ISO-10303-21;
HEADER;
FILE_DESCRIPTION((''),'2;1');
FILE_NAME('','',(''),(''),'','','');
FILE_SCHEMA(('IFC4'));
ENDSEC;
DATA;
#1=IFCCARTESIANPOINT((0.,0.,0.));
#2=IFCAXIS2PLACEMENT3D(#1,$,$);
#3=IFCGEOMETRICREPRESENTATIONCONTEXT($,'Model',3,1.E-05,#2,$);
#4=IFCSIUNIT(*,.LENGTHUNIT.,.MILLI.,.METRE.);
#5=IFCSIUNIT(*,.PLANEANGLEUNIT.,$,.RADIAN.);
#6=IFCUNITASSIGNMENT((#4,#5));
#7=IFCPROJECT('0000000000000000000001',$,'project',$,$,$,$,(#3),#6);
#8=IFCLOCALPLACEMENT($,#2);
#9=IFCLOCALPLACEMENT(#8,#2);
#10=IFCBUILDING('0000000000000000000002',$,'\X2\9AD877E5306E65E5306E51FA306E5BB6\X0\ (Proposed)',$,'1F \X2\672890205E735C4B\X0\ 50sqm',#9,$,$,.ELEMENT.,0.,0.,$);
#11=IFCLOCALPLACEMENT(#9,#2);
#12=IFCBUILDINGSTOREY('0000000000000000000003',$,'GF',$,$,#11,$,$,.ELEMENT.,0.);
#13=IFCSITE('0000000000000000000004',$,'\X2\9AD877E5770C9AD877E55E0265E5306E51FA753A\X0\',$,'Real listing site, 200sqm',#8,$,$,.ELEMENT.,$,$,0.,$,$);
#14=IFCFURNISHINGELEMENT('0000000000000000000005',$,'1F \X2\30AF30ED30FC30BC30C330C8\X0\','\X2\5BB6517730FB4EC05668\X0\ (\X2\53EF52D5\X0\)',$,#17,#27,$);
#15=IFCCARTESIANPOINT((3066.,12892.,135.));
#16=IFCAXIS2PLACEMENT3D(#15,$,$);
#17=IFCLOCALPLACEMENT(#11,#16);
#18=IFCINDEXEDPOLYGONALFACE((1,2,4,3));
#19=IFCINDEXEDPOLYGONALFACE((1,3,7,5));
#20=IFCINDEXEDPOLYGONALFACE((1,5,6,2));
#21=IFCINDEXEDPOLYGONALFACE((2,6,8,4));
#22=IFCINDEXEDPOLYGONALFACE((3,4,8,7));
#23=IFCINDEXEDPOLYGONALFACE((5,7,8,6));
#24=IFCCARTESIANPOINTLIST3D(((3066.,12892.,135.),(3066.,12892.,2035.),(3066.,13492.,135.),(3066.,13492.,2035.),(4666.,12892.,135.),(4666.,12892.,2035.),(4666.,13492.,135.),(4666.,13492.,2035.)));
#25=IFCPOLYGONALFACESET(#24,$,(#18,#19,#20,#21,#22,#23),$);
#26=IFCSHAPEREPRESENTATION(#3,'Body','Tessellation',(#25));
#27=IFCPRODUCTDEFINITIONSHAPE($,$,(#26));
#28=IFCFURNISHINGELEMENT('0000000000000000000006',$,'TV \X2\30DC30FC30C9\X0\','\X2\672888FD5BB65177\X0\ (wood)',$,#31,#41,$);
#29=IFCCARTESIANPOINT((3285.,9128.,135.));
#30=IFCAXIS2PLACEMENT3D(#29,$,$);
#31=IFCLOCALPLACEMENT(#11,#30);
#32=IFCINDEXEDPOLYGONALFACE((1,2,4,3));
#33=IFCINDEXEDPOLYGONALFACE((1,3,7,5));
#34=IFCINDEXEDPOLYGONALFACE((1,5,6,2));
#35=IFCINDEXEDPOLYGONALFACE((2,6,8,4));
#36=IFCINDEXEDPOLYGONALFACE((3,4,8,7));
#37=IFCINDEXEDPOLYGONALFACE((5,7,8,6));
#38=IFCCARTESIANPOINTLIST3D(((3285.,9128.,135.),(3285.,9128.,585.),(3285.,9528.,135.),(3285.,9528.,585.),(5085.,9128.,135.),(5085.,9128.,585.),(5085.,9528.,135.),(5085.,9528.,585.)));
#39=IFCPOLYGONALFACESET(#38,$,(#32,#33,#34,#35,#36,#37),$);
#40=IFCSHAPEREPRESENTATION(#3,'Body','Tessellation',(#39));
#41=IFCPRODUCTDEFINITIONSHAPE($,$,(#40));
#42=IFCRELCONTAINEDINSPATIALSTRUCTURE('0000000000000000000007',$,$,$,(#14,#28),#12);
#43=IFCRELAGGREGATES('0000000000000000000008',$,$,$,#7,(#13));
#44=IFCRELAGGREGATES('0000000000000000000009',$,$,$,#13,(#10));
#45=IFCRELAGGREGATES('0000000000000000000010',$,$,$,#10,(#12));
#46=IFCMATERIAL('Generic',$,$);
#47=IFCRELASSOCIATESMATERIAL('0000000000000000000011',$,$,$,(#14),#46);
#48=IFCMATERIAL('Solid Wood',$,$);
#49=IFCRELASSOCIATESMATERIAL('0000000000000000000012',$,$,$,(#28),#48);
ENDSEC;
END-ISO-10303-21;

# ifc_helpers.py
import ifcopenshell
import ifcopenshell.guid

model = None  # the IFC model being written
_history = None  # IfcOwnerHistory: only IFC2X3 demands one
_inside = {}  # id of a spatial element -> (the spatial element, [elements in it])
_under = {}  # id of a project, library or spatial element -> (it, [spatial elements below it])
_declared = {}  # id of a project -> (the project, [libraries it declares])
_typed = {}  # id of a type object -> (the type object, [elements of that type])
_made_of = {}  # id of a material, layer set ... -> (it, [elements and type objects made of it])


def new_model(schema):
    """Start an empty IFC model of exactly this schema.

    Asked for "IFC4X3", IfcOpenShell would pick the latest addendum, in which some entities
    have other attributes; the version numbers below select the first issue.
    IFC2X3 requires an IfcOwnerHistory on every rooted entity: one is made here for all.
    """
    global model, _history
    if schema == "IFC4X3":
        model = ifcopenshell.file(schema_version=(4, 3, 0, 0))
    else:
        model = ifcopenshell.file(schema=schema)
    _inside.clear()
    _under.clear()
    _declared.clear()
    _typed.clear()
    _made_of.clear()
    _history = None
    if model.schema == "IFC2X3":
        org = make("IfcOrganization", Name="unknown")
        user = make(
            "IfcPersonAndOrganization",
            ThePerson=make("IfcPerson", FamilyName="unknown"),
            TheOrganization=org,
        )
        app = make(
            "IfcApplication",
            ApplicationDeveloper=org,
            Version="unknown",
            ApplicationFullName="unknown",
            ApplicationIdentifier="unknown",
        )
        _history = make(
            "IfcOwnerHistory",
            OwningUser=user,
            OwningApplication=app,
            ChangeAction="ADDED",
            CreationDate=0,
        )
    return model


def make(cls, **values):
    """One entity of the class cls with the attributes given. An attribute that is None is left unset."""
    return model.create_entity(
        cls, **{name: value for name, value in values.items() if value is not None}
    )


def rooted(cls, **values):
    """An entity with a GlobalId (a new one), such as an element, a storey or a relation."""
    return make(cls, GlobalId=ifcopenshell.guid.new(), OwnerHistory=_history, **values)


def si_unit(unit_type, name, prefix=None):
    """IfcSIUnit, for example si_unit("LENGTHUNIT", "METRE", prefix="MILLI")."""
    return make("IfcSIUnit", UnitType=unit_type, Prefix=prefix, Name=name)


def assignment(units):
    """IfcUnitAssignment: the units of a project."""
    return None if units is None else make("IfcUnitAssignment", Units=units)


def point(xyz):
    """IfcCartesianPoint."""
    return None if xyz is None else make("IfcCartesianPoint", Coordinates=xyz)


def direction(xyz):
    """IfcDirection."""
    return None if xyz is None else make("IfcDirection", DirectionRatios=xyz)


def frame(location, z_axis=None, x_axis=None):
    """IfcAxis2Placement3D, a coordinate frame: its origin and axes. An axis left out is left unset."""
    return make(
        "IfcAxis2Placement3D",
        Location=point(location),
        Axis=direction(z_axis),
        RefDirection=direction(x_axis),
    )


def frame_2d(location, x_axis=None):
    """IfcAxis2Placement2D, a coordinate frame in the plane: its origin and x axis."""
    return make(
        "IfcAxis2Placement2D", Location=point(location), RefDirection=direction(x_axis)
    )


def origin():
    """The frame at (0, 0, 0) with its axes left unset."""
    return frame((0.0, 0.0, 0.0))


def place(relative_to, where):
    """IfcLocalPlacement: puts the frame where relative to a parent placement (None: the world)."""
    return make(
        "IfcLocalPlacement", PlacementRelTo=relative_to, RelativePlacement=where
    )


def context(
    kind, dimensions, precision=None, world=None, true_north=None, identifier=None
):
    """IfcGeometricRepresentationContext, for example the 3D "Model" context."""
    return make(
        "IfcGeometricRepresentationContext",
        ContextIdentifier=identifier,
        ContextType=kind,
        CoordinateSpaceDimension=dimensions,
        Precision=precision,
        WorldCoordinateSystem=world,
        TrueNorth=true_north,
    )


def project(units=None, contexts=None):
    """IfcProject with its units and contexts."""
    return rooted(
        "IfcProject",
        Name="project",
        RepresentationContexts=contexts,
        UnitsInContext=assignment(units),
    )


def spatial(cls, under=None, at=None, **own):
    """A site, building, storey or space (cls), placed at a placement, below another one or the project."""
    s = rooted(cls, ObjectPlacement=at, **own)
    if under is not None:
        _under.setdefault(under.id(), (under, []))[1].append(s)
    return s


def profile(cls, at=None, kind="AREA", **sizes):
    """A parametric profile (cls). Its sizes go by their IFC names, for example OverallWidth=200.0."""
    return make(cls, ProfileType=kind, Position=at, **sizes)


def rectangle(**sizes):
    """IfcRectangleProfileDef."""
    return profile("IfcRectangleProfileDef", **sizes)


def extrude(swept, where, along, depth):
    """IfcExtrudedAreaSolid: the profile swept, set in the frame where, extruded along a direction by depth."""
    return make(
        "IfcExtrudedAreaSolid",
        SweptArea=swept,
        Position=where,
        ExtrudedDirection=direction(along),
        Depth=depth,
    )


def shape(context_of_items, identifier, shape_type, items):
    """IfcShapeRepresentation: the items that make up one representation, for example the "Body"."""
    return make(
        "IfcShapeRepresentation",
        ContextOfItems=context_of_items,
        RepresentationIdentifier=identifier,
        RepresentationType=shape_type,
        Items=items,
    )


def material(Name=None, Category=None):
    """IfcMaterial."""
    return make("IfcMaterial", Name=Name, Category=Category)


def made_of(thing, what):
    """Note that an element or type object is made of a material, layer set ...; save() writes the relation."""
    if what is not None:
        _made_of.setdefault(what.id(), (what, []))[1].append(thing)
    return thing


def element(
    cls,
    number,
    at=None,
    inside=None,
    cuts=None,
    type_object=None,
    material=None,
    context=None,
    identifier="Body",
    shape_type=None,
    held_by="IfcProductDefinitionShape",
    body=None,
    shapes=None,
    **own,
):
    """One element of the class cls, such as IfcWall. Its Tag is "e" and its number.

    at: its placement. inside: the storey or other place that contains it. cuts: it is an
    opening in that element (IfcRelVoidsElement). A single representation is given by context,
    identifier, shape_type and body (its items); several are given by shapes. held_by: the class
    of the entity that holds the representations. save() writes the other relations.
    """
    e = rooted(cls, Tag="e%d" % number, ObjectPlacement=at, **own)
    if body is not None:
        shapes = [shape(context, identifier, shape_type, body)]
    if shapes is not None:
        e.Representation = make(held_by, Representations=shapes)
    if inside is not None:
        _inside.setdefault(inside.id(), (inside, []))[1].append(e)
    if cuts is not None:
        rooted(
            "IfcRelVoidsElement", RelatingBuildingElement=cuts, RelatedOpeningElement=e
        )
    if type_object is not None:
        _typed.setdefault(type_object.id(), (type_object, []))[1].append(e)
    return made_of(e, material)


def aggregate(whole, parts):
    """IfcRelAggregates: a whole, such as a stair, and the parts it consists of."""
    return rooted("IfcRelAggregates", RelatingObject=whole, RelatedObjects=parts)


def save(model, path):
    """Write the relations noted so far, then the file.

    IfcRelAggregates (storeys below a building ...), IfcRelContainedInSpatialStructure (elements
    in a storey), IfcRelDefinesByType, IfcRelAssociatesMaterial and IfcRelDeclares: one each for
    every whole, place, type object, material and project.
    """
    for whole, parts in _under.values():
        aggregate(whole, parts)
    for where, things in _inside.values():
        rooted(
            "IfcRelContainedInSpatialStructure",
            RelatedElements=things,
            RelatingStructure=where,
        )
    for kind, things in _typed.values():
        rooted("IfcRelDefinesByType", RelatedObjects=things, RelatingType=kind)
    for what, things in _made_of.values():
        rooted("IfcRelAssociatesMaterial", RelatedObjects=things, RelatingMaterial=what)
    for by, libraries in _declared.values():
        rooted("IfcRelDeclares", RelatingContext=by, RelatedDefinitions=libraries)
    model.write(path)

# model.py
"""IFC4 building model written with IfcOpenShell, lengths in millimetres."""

from ifc_helpers import new_model, si_unit, frame, frame_2d, origin, place, context, project, spatial, rectangle, extrude, material, element, save


model = new_model("IFC4")

# Units and contexts
model_context = context("Model", 3, precision=1e-05, world=origin())
ifc_project = project(units=[si_unit("LENGTHUNIT", "METRE", prefix="MILLI"), si_unit("PLANEANGLEUNIT", "RADIAN")], contexts=[model_context])

# Site, building, storey
site_placement = place(None, origin())
site = spatial("IfcSite", under=ifc_project, at=site_placement, Name="高知県高知市日の出町", ObjectType="Real listing site, 200sqm", CompositionType="ELEMENT", RefElevation=0.0)
building_placement = place(site_placement, origin())
building = spatial("IfcBuilding", under=site, at=building_placement, Name="高知の日の出の家 (Proposed)", ObjectType="1F 木造平屋 50sqm", CompositionType="ELEMENT", ElevationOfRefHeight=0.0, ElevationOfTerrain=0.0)
storey_placement = place(building_placement, origin())
storey = spatial("IfcBuildingStorey", under=building, at=storey_placement, Name="GF", CompositionType="ELEMENT", Elevation=0.0)

# Shared definitions
ifc_material_1 = material(Name="Solid Wood")

# Shared definitions
ifc_material_2 = material(Name="Generic")

# Furnishing elements
furnishing_1_placement = place(storey_placement, frame((3066.0, 12892.0, 135.0)))
element("IfcFurnishingElement", 1, at=furnishing_1_placement, inside=storey, material=ifc_material_2, Name="1F クローゼット", Description="家具・什器 (可動)", context=model_context, shape_type="SweptSolid", body=[
    extrude(rectangle(XDim=1600.0, YDim=600.0, at=frame_2d((800.0, 300.0))), frame((3066.0, 12892.0, 135.0)), (0.0, 0.0, 1.0), 1900.0),
])
furnishing_2_placement = place(storey_placement, frame((3285.0, 9128.0, 135.0)))
element("IfcFurnishingElement", 2, at=furnishing_2_placement, inside=storey, material=ifc_material_1, Name="TV ボード", Description="木製家具 (wood)", context=model_context, shape_type="SweptSolid", body=[
    extrude(rectangle(XDim=1800.0, YDim=400.0, at=frame_2d((900.0, 200.0))), frame((3285.0, 9128.0, 135.0)), (0.0, 0.0, 1.0), 450.0),
])

save(model, "model.ifc")
